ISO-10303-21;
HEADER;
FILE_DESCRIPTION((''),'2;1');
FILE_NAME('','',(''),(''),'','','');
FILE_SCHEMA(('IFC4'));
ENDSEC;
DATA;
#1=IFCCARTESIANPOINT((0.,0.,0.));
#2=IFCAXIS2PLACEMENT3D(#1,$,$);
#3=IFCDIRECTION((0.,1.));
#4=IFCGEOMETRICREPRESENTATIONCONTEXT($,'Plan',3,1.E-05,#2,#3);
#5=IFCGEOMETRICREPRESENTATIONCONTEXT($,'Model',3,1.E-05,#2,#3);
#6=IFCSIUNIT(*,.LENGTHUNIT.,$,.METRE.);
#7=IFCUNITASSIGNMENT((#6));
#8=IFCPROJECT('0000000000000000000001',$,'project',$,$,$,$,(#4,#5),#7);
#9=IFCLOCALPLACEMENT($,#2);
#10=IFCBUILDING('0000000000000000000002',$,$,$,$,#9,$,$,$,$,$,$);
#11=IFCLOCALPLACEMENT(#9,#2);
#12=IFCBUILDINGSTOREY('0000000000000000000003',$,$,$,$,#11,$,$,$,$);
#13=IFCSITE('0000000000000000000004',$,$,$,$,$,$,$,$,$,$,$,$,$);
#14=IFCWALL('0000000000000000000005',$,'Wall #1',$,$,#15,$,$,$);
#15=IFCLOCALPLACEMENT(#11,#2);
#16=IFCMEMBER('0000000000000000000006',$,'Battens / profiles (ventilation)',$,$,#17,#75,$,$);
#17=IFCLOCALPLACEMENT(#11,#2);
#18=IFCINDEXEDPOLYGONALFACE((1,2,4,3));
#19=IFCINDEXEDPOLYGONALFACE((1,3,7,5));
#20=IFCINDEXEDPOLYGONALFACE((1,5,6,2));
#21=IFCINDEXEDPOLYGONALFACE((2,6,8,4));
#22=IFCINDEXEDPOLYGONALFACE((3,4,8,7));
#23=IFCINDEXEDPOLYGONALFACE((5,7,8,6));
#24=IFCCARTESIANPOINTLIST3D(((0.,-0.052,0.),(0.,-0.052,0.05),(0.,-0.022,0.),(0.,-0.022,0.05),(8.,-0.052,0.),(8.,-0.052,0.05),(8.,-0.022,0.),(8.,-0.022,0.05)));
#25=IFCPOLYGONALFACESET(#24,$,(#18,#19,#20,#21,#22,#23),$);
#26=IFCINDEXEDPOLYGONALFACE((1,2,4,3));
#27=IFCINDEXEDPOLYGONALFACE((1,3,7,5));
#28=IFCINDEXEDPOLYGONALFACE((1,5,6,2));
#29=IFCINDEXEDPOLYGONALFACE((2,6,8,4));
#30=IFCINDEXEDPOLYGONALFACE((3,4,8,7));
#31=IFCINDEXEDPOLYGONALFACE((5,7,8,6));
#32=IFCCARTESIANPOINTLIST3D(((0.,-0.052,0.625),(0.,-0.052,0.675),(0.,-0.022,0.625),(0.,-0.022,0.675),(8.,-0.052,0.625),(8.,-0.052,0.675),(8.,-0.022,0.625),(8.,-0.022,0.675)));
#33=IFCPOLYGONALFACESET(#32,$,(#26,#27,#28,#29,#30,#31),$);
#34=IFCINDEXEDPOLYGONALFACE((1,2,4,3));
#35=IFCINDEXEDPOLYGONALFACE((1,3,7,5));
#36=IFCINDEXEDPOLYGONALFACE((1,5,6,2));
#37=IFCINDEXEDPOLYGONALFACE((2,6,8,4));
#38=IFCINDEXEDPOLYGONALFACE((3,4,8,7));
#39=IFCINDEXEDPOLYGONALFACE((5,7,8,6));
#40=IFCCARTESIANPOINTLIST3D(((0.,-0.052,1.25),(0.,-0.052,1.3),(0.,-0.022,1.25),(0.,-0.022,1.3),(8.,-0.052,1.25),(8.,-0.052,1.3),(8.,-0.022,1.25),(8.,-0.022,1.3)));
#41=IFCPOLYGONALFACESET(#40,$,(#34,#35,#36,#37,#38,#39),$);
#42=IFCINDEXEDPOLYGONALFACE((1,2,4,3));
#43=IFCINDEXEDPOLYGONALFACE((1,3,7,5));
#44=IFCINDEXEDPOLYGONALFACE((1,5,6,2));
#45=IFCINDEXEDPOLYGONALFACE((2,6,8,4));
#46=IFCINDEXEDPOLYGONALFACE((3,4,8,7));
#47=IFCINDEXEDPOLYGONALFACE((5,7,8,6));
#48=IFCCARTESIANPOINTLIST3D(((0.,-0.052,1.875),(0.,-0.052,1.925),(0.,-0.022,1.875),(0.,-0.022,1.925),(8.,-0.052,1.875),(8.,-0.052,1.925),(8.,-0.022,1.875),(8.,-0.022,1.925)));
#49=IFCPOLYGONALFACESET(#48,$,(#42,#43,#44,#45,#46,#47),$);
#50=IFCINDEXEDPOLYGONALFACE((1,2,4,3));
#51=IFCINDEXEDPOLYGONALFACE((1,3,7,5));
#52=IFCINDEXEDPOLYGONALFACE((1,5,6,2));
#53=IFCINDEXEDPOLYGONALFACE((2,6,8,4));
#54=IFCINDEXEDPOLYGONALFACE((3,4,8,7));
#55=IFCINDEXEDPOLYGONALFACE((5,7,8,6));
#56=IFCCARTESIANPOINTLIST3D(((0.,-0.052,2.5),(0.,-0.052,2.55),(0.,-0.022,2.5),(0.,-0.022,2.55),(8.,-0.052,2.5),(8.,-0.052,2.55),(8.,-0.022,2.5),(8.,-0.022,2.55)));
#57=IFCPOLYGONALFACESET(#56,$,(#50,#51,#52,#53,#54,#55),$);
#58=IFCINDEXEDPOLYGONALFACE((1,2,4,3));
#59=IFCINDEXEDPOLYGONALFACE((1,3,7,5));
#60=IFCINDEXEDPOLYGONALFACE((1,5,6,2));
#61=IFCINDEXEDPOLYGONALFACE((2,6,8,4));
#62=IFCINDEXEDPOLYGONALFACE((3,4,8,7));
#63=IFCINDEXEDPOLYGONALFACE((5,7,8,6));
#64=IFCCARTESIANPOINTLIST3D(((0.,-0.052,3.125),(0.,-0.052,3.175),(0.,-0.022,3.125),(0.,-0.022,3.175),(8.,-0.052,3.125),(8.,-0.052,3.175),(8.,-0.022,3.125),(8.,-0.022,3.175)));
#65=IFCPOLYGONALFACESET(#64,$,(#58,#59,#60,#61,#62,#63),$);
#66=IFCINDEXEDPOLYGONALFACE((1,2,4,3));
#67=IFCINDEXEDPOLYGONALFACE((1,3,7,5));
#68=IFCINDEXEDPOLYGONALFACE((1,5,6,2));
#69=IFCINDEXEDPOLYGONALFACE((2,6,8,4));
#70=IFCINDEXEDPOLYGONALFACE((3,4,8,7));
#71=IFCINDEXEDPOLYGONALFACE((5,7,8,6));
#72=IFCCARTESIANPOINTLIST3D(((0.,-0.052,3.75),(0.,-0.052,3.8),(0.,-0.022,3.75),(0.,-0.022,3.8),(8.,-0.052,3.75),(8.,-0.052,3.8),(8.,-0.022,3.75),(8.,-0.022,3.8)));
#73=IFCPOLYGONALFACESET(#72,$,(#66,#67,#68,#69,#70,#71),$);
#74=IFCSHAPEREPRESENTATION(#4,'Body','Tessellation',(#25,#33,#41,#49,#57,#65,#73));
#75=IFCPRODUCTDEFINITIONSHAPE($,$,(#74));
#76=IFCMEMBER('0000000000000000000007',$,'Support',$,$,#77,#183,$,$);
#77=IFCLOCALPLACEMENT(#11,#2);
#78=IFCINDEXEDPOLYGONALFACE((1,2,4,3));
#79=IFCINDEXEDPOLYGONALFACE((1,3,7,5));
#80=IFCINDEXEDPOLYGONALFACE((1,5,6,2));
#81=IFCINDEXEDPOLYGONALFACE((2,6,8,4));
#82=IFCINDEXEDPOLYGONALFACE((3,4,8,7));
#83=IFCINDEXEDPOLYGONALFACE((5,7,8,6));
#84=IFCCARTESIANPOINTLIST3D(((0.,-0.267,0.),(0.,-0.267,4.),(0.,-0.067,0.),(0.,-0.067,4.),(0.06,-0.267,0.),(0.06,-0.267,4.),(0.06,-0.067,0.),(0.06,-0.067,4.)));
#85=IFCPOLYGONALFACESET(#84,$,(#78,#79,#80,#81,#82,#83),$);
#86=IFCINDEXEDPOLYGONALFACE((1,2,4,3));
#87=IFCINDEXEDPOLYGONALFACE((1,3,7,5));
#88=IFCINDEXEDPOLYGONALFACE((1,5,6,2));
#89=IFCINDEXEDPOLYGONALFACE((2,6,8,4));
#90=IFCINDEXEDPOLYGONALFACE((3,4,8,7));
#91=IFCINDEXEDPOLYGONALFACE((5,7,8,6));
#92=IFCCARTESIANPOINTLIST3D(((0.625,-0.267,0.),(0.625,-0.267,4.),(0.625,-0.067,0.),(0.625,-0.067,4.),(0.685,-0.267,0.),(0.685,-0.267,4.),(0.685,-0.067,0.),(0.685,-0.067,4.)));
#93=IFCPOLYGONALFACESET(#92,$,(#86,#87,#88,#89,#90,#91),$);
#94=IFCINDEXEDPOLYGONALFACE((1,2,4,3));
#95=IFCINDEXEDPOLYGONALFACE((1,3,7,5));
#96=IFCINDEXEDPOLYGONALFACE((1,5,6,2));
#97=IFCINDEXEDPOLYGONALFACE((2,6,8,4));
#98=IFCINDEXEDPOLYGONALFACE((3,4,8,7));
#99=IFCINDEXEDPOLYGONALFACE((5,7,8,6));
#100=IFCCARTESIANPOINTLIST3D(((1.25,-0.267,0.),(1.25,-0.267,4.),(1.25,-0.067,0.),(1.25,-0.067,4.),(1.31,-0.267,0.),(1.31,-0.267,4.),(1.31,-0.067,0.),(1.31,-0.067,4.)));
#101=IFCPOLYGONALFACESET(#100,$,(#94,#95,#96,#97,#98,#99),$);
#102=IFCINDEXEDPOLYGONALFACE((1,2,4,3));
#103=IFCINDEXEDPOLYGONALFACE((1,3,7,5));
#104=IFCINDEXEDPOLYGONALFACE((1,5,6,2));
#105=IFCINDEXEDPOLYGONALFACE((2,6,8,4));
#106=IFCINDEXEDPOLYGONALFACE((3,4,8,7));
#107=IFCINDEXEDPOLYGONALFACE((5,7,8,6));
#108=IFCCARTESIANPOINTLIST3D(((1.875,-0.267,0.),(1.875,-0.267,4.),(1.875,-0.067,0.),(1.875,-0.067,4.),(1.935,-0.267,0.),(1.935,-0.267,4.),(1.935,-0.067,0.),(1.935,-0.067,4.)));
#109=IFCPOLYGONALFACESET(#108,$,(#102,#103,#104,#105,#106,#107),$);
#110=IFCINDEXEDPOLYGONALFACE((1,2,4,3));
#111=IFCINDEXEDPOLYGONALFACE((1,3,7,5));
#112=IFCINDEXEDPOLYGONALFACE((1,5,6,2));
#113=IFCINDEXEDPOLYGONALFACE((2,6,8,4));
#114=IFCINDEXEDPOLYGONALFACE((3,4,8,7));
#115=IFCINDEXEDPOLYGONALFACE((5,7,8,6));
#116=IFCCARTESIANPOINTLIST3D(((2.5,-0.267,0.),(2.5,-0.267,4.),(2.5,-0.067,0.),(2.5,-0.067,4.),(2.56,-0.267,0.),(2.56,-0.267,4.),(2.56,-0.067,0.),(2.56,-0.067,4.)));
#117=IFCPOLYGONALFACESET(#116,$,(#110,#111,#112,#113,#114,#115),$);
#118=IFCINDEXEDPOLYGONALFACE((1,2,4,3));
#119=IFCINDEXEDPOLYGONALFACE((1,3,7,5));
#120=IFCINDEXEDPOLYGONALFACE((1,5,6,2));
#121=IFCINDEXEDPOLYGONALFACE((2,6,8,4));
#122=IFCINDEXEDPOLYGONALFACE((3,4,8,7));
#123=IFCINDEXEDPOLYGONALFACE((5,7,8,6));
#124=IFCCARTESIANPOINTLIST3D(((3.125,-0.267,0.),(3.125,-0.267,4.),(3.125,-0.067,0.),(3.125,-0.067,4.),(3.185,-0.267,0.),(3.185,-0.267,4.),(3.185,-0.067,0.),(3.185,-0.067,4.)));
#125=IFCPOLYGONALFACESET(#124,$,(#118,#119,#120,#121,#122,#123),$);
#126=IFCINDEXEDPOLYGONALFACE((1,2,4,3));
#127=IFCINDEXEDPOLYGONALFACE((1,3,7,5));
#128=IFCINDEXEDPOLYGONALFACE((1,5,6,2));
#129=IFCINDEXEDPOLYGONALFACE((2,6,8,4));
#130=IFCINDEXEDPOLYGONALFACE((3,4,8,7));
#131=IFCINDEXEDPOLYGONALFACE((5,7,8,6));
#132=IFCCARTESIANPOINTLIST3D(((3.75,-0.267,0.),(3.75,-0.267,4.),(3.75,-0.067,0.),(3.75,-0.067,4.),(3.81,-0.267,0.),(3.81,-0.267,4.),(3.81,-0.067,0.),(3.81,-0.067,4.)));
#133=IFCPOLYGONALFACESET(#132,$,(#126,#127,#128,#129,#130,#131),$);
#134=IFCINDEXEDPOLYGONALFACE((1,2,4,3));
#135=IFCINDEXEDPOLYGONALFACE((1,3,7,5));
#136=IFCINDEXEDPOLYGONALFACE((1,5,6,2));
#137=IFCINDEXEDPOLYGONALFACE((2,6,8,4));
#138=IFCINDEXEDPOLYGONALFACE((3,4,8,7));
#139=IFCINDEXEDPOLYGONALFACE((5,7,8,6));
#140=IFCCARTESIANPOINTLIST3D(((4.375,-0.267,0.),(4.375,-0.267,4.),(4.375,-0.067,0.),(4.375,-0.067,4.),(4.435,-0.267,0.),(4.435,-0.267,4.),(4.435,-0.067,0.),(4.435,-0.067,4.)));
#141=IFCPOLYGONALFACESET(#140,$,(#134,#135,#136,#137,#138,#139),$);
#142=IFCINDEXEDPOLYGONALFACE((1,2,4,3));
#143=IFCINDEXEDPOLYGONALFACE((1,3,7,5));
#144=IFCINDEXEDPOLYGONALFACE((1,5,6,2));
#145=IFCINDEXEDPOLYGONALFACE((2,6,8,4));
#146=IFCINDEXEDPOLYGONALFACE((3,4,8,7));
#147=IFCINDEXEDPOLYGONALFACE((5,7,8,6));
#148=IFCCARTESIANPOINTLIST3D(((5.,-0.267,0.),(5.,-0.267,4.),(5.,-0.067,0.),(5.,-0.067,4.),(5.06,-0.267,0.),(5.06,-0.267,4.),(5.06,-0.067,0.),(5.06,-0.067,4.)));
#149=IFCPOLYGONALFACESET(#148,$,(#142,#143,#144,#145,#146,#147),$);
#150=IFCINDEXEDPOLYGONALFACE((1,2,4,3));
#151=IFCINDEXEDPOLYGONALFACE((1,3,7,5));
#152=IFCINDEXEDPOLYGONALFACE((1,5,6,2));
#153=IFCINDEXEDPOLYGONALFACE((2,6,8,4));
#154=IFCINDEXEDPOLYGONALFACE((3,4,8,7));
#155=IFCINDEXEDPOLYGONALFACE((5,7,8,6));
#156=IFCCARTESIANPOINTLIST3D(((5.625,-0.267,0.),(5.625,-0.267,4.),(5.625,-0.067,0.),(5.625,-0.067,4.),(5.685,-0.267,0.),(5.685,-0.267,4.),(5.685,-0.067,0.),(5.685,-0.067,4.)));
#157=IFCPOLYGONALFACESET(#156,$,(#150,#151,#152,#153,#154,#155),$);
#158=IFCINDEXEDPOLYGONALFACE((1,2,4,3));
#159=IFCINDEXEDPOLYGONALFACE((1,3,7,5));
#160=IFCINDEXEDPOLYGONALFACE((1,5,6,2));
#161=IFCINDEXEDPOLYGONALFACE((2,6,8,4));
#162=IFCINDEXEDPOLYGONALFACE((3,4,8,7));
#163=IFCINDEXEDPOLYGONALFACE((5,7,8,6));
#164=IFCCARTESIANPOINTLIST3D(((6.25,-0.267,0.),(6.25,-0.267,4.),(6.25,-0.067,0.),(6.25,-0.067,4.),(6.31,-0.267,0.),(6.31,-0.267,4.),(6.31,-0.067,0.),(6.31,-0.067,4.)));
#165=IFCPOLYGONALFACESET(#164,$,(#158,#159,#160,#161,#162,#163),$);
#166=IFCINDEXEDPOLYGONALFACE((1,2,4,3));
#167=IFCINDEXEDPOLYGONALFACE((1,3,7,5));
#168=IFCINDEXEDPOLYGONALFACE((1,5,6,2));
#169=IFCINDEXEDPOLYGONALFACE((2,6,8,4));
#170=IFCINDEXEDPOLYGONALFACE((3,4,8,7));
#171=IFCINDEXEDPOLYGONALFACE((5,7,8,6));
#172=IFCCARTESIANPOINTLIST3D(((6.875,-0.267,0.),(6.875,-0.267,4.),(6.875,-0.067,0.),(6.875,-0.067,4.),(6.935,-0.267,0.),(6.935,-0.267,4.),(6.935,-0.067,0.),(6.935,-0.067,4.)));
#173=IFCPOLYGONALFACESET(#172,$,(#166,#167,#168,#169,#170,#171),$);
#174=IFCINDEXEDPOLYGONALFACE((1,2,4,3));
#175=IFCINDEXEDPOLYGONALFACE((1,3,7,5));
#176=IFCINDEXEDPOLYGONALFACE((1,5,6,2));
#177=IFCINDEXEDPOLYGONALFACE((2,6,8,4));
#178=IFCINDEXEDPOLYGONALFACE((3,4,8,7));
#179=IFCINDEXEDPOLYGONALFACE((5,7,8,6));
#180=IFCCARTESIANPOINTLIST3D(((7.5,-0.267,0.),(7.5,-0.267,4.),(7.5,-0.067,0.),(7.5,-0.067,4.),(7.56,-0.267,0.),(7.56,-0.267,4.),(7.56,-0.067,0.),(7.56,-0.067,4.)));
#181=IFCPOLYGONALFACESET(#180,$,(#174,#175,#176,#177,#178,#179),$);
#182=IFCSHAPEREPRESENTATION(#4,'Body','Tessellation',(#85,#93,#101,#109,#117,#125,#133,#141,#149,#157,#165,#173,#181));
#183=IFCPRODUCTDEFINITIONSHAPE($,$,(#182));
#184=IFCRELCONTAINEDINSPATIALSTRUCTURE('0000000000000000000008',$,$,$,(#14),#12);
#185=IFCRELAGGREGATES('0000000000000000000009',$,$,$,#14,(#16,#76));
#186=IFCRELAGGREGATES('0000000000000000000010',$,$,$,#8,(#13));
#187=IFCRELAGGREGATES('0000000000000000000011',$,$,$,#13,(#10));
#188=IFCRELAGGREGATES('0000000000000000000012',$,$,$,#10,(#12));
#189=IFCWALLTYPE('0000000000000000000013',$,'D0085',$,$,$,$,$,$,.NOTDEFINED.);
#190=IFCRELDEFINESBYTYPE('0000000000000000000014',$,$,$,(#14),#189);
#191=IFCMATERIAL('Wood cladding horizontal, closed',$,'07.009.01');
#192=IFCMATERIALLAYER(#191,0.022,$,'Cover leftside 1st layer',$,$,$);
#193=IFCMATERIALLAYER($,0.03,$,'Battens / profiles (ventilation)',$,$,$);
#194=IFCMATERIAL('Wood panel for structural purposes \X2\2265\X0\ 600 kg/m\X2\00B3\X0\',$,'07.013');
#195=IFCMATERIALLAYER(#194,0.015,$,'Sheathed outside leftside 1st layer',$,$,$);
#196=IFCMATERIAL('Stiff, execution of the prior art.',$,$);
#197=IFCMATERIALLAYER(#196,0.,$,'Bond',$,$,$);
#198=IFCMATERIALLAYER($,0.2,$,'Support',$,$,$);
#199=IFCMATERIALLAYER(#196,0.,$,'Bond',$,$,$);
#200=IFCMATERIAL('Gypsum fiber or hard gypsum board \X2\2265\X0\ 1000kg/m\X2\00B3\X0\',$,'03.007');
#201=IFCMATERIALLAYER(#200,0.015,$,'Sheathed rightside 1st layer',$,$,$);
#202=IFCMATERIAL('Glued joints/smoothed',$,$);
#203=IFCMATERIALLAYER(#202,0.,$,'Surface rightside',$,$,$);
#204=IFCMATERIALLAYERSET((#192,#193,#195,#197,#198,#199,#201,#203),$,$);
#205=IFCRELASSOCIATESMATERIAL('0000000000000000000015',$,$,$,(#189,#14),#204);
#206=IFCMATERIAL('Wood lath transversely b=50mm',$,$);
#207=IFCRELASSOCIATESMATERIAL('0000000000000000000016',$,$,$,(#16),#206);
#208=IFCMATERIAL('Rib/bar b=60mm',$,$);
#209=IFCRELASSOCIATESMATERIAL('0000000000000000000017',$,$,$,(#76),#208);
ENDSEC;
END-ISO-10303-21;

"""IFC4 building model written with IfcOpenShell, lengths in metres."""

from ifc_helpers import new_model, si_unit, direction, frame, frame_2d, origin, place, context, project, spatial, rectangle, extrude, material, layer, layer_set, type_object, element, aggregate, save


model = new_model("IFC4")

# Units and contexts
plan_context = context("Plan", 3, precision=1e-05, world=origin(), true_north=direction((0.0, 1.0)))
model_context = context("Model", 3, precision=1e-05, world=origin(), true_north=direction((0.0, 1.0)))
ifc_project = project(units=[si_unit("LENGTHUNIT", "METRE")], contexts=[plan_context, model_context])

# Site, building, storey
site = spatial("IfcSite", under=ifc_project)
building_placement = place(None, origin())
building = spatial("IfcBuilding", under=site, at=building_placement)
storey_placement = place(building_placement, origin())
storey = spatial("IfcBuildingStorey", under=building, at=storey_placement)

# Wall, members
ifc_material_1 = material(Name="Wood cladding horizontal, closed", Category="07.009.01")
ifc_layer_1 = layer(ifc_material_1, 0.022, Name="Cover leftside 1st layer")
ifc_layer_2 = layer(None, 0.03, Name="Battens / profiles (ventilation)")
ifc_material_2 = material(Name="Wood panel for structural purposes ≥ 600 kg/m³", Category="07.013")
ifc_layer_3 = layer(ifc_material_2, 0.015, Name="Sheathed outside leftside 1st layer")
ifc_material_3 = material(Name="Stiff, execution of the prior art.")
ifc_layer_4 = layer(ifc_material_3, 0.0, Name="Bond")
ifc_layer_5 = layer(None, 0.2, Name="Support")
ifc_layer_6 = layer(ifc_material_3, 0.0, Name="Bond")
ifc_material_4 = material(Name="Gypsum fiber or hard gypsum board ≥ 1000kg/m³", Category="03.007")
ifc_layer_7 = layer(ifc_material_4, 0.015, Name="Sheathed rightside 1st layer")
ifc_material_5 = material(Name="Glued joints/smoothed")
ifc_layer_8 = layer(ifc_material_5, 0.0, Name="Surface rightside")
ifc_layer_set = layer_set([ifc_layer_1, ifc_layer_2, ifc_layer_3, ifc_layer_4, ifc_layer_5, ifc_layer_6, ifc_layer_7, ifc_layer_8])
wall_type = type_object("IfcWallType", Name="D0085", PredefinedType="NOTDEFINED", material=ifc_layer_set)
wall_placement = place(None, frame((0.0, 0.0, 0.0), z_axis=(0.0, -1.0, 0.0), x_axis=(1.0, 0.0, 0.0)))
wall = element("IfcWall", 1, at=wall_placement, inside=storey, type_object=wall_type, material=ifc_layer_set, Name="Wall #1")
ifc_material_6 = material(Name="Wood lath transversely b=50mm")
member_1_placement = place(wall_placement, origin())
member_1 = element("IfcMember", 2, at=member_1_placement, material=ifc_material_6, Name="Battens / profiles (ventilation)", context=plan_context, shape_type="SweptSolid", body=[
    extrude(rectangle(XDim=0.05, YDim=0.03, at=frame_2d((0.025, 0.015), x_axis=(1.0, 0.0))), frame((0.0, 0.0, 0.022), z_axis=(1.0, 0.0, 0.0), x_axis=(0.0, 1.0, 0.0)), (0.0, 0.0, 1.0), 8.0),
    extrude(rectangle(XDim=0.05, YDim=0.03, at=frame_2d((0.025, 0.015), x_axis=(1.0, 0.0))), frame((0.0, 0.625, 0.022), z_axis=(1.0, 0.0, 0.0), x_axis=(0.0, 1.0, 0.0)), (0.0, 0.0, 1.0), 8.0),
    extrude(rectangle(XDim=0.05, YDim=0.03, at=frame_2d((0.025, 0.015), x_axis=(1.0, 0.0))), frame((0.0, 1.25, 0.022), z_axis=(1.0, 0.0, 0.0), x_axis=(0.0, 1.0, 0.0)), (0.0, 0.0, 1.0), 8.0),
    extrude(rectangle(XDim=0.05, YDim=0.03, at=frame_2d((0.025, 0.015), x_axis=(1.0, 0.0))), frame((0.0, 1.875, 0.022), z_axis=(1.0, 0.0, 0.0), x_axis=(0.0, 1.0, 0.0)), (0.0, 0.0, 1.0), 8.0),
    extrude(rectangle(XDim=0.05, YDim=0.03, at=frame_2d((0.025, 0.015), x_axis=(1.0, 0.0))), frame((0.0, 2.5, 0.022), z_axis=(1.0, 0.0, 0.0), x_axis=(0.0, 1.0, 0.0)), (0.0, 0.0, 1.0), 8.0),
    extrude(rectangle(XDim=0.05, YDim=0.03, at=frame_2d((0.025, 0.015), x_axis=(1.0, 0.0))), frame((0.0, 3.125, 0.022), z_axis=(1.0, 0.0, 0.0), x_axis=(0.0, 1.0, 0.0)), (0.0, 0.0, 1.0), 8.0),
    extrude(rectangle(XDim=0.05, YDim=0.03, at=frame_2d((0.025, 0.015), x_axis=(1.0, 0.0))), frame((0.0, 3.75, 0.022), z_axis=(1.0, 0.0, 0.0), x_axis=(0.0, 1.0, 0.0)), (0.0, 0.0, 1.0), 8.0),
])
ifc_material_7 = material(Name="Rib/bar b=60mm")
member_2_placement = place(wall_placement, origin())
member_2 = element("IfcMember", 3, at=member_2_placement, material=ifc_material_7, Name="Support", context=plan_context, shape_type="SweptSolid", body=[
    extrude(rectangle(XDim=0.06, YDim=0.2, at=frame_2d((0.03, 0.1), x_axis=(1.0, 0.0))), frame((0.0, 4.0, 0.067), z_axis=(0.0, -1.0, 0.0), x_axis=(1.0, 0.0, 0.0)), (0.0, 0.0, 1.0), 4.0),
    extrude(rectangle(XDim=0.06, YDim=0.2, at=frame_2d((0.03, 0.1), x_axis=(1.0, 0.0))), frame((0.625, 4.0, 0.067), z_axis=(0.0, -1.0, 0.0), x_axis=(1.0, 0.0, 0.0)), (0.0, 0.0, 1.0), 4.0),
    extrude(rectangle(XDim=0.06, YDim=0.2, at=frame_2d((0.03, 0.1), x_axis=(1.0, 0.0))), frame((1.25, 4.0, 0.067), z_axis=(0.0, -1.0, 0.0), x_axis=(1.0, 0.0, 0.0)), (0.0, 0.0, 1.0), 4.0),
    extrude(rectangle(XDim=0.06, YDim=0.2, at=frame_2d((0.03, 0.1), x_axis=(1.0, 0.0))), frame((1.875, 4.0, 0.067), z_axis=(0.0, -1.0, 0.0), x_axis=(1.0, 0.0, 0.0)), (0.0, 0.0, 1.0), 4.0),
    extrude(rectangle(XDim=0.06, YDim=0.2, at=frame_2d((0.03, 0.1), x_axis=(1.0, 0.0))), frame((2.5, 4.0, 0.067), z_axis=(0.0, -1.0, 0.0), x_axis=(1.0, 0.0, 0.0)), (0.0, 0.0, 1.0), 4.0),
    extrude(rectangle(XDim=0.06, YDim=0.2, at=frame_2d((0.03, 0.1), x_axis=(1.0, 0.0))), frame((3.125, 4.0, 0.067), z_axis=(0.0, -1.0, 0.0), x_axis=(1.0, 0.0, 0.0)), (0.0, 0.0, 1.0), 4.0),
    extrude(rectangle(XDim=0.06, YDim=0.2, at=frame_2d((0.03, 0.1), x_axis=(1.0, 0.0))), frame((3.75, 4.0, 0.067), z_axis=(0.0, -1.0, 0.0), x_axis=(1.0, 0.0, 0.0)), (0.0, 0.0, 1.0), 4.0),
    extrude(rectangle(XDim=0.06, YDim=0.2, at=frame_2d((0.03, 0.1), x_axis=(1.0, 0.0))), frame((4.375, 4.0, 0.067), z_axis=(0.0, -1.0, 0.0), x_axis=(1.0, 0.0, 0.0)), (0.0, 0.0, 1.0), 4.0),
    extrude(rectangle(XDim=0.06, YDim=0.2, at=frame_2d((0.03, 0.1), x_axis=(1.0, 0.0))), frame((5.0, 4.0, 0.067), z_axis=(0.0, -1.0, 0.0), x_axis=(1.0, 0.0, 0.0)), (0.0, 0.0, 1.0), 4.0),
    extrude(rectangle(XDim=0.06, YDim=0.2, at=frame_2d((0.03, 0.1), x_axis=(1.0, 0.0))), frame((5.625, 4.0, 0.067), z_axis=(0.0, -1.0, 0.0), x_axis=(1.0, 0.0, 0.0)), (0.0, 0.0, 1.0), 4.0),
    extrude(rectangle(XDim=0.06, YDim=0.2, at=frame_2d((0.03, 0.1), x_axis=(1.0, 0.0))), frame((6.25, 4.0, 0.067), z_axis=(0.0, -1.0, 0.0), x_axis=(1.0, 0.0, 0.0)), (0.0, 0.0, 1.0), 4.0),
    extrude(rectangle(XDim=0.06, YDim=0.2, at=frame_2d((0.03, 0.1), x_axis=(1.0, 0.0))), frame((6.875, 4.0, 0.067), z_axis=(0.0, -1.0, 0.0), x_axis=(1.0, 0.0, 0.0)), (0.0, 0.0, 1.0), 4.0),
    extrude(rectangle(XDim=0.06, YDim=0.2, at=frame_2d((0.03, 0.1), x_axis=(1.0, 0.0))), frame((7.5, 4.0, 0.067), z_axis=(0.0, -1.0, 0.0), x_axis=(1.0, 0.0, 0.0)), (0.0, 0.0, 1.0), 4.0),
])
aggregate(wall, [member_1, member_2])

save(model, "model.ifc")
